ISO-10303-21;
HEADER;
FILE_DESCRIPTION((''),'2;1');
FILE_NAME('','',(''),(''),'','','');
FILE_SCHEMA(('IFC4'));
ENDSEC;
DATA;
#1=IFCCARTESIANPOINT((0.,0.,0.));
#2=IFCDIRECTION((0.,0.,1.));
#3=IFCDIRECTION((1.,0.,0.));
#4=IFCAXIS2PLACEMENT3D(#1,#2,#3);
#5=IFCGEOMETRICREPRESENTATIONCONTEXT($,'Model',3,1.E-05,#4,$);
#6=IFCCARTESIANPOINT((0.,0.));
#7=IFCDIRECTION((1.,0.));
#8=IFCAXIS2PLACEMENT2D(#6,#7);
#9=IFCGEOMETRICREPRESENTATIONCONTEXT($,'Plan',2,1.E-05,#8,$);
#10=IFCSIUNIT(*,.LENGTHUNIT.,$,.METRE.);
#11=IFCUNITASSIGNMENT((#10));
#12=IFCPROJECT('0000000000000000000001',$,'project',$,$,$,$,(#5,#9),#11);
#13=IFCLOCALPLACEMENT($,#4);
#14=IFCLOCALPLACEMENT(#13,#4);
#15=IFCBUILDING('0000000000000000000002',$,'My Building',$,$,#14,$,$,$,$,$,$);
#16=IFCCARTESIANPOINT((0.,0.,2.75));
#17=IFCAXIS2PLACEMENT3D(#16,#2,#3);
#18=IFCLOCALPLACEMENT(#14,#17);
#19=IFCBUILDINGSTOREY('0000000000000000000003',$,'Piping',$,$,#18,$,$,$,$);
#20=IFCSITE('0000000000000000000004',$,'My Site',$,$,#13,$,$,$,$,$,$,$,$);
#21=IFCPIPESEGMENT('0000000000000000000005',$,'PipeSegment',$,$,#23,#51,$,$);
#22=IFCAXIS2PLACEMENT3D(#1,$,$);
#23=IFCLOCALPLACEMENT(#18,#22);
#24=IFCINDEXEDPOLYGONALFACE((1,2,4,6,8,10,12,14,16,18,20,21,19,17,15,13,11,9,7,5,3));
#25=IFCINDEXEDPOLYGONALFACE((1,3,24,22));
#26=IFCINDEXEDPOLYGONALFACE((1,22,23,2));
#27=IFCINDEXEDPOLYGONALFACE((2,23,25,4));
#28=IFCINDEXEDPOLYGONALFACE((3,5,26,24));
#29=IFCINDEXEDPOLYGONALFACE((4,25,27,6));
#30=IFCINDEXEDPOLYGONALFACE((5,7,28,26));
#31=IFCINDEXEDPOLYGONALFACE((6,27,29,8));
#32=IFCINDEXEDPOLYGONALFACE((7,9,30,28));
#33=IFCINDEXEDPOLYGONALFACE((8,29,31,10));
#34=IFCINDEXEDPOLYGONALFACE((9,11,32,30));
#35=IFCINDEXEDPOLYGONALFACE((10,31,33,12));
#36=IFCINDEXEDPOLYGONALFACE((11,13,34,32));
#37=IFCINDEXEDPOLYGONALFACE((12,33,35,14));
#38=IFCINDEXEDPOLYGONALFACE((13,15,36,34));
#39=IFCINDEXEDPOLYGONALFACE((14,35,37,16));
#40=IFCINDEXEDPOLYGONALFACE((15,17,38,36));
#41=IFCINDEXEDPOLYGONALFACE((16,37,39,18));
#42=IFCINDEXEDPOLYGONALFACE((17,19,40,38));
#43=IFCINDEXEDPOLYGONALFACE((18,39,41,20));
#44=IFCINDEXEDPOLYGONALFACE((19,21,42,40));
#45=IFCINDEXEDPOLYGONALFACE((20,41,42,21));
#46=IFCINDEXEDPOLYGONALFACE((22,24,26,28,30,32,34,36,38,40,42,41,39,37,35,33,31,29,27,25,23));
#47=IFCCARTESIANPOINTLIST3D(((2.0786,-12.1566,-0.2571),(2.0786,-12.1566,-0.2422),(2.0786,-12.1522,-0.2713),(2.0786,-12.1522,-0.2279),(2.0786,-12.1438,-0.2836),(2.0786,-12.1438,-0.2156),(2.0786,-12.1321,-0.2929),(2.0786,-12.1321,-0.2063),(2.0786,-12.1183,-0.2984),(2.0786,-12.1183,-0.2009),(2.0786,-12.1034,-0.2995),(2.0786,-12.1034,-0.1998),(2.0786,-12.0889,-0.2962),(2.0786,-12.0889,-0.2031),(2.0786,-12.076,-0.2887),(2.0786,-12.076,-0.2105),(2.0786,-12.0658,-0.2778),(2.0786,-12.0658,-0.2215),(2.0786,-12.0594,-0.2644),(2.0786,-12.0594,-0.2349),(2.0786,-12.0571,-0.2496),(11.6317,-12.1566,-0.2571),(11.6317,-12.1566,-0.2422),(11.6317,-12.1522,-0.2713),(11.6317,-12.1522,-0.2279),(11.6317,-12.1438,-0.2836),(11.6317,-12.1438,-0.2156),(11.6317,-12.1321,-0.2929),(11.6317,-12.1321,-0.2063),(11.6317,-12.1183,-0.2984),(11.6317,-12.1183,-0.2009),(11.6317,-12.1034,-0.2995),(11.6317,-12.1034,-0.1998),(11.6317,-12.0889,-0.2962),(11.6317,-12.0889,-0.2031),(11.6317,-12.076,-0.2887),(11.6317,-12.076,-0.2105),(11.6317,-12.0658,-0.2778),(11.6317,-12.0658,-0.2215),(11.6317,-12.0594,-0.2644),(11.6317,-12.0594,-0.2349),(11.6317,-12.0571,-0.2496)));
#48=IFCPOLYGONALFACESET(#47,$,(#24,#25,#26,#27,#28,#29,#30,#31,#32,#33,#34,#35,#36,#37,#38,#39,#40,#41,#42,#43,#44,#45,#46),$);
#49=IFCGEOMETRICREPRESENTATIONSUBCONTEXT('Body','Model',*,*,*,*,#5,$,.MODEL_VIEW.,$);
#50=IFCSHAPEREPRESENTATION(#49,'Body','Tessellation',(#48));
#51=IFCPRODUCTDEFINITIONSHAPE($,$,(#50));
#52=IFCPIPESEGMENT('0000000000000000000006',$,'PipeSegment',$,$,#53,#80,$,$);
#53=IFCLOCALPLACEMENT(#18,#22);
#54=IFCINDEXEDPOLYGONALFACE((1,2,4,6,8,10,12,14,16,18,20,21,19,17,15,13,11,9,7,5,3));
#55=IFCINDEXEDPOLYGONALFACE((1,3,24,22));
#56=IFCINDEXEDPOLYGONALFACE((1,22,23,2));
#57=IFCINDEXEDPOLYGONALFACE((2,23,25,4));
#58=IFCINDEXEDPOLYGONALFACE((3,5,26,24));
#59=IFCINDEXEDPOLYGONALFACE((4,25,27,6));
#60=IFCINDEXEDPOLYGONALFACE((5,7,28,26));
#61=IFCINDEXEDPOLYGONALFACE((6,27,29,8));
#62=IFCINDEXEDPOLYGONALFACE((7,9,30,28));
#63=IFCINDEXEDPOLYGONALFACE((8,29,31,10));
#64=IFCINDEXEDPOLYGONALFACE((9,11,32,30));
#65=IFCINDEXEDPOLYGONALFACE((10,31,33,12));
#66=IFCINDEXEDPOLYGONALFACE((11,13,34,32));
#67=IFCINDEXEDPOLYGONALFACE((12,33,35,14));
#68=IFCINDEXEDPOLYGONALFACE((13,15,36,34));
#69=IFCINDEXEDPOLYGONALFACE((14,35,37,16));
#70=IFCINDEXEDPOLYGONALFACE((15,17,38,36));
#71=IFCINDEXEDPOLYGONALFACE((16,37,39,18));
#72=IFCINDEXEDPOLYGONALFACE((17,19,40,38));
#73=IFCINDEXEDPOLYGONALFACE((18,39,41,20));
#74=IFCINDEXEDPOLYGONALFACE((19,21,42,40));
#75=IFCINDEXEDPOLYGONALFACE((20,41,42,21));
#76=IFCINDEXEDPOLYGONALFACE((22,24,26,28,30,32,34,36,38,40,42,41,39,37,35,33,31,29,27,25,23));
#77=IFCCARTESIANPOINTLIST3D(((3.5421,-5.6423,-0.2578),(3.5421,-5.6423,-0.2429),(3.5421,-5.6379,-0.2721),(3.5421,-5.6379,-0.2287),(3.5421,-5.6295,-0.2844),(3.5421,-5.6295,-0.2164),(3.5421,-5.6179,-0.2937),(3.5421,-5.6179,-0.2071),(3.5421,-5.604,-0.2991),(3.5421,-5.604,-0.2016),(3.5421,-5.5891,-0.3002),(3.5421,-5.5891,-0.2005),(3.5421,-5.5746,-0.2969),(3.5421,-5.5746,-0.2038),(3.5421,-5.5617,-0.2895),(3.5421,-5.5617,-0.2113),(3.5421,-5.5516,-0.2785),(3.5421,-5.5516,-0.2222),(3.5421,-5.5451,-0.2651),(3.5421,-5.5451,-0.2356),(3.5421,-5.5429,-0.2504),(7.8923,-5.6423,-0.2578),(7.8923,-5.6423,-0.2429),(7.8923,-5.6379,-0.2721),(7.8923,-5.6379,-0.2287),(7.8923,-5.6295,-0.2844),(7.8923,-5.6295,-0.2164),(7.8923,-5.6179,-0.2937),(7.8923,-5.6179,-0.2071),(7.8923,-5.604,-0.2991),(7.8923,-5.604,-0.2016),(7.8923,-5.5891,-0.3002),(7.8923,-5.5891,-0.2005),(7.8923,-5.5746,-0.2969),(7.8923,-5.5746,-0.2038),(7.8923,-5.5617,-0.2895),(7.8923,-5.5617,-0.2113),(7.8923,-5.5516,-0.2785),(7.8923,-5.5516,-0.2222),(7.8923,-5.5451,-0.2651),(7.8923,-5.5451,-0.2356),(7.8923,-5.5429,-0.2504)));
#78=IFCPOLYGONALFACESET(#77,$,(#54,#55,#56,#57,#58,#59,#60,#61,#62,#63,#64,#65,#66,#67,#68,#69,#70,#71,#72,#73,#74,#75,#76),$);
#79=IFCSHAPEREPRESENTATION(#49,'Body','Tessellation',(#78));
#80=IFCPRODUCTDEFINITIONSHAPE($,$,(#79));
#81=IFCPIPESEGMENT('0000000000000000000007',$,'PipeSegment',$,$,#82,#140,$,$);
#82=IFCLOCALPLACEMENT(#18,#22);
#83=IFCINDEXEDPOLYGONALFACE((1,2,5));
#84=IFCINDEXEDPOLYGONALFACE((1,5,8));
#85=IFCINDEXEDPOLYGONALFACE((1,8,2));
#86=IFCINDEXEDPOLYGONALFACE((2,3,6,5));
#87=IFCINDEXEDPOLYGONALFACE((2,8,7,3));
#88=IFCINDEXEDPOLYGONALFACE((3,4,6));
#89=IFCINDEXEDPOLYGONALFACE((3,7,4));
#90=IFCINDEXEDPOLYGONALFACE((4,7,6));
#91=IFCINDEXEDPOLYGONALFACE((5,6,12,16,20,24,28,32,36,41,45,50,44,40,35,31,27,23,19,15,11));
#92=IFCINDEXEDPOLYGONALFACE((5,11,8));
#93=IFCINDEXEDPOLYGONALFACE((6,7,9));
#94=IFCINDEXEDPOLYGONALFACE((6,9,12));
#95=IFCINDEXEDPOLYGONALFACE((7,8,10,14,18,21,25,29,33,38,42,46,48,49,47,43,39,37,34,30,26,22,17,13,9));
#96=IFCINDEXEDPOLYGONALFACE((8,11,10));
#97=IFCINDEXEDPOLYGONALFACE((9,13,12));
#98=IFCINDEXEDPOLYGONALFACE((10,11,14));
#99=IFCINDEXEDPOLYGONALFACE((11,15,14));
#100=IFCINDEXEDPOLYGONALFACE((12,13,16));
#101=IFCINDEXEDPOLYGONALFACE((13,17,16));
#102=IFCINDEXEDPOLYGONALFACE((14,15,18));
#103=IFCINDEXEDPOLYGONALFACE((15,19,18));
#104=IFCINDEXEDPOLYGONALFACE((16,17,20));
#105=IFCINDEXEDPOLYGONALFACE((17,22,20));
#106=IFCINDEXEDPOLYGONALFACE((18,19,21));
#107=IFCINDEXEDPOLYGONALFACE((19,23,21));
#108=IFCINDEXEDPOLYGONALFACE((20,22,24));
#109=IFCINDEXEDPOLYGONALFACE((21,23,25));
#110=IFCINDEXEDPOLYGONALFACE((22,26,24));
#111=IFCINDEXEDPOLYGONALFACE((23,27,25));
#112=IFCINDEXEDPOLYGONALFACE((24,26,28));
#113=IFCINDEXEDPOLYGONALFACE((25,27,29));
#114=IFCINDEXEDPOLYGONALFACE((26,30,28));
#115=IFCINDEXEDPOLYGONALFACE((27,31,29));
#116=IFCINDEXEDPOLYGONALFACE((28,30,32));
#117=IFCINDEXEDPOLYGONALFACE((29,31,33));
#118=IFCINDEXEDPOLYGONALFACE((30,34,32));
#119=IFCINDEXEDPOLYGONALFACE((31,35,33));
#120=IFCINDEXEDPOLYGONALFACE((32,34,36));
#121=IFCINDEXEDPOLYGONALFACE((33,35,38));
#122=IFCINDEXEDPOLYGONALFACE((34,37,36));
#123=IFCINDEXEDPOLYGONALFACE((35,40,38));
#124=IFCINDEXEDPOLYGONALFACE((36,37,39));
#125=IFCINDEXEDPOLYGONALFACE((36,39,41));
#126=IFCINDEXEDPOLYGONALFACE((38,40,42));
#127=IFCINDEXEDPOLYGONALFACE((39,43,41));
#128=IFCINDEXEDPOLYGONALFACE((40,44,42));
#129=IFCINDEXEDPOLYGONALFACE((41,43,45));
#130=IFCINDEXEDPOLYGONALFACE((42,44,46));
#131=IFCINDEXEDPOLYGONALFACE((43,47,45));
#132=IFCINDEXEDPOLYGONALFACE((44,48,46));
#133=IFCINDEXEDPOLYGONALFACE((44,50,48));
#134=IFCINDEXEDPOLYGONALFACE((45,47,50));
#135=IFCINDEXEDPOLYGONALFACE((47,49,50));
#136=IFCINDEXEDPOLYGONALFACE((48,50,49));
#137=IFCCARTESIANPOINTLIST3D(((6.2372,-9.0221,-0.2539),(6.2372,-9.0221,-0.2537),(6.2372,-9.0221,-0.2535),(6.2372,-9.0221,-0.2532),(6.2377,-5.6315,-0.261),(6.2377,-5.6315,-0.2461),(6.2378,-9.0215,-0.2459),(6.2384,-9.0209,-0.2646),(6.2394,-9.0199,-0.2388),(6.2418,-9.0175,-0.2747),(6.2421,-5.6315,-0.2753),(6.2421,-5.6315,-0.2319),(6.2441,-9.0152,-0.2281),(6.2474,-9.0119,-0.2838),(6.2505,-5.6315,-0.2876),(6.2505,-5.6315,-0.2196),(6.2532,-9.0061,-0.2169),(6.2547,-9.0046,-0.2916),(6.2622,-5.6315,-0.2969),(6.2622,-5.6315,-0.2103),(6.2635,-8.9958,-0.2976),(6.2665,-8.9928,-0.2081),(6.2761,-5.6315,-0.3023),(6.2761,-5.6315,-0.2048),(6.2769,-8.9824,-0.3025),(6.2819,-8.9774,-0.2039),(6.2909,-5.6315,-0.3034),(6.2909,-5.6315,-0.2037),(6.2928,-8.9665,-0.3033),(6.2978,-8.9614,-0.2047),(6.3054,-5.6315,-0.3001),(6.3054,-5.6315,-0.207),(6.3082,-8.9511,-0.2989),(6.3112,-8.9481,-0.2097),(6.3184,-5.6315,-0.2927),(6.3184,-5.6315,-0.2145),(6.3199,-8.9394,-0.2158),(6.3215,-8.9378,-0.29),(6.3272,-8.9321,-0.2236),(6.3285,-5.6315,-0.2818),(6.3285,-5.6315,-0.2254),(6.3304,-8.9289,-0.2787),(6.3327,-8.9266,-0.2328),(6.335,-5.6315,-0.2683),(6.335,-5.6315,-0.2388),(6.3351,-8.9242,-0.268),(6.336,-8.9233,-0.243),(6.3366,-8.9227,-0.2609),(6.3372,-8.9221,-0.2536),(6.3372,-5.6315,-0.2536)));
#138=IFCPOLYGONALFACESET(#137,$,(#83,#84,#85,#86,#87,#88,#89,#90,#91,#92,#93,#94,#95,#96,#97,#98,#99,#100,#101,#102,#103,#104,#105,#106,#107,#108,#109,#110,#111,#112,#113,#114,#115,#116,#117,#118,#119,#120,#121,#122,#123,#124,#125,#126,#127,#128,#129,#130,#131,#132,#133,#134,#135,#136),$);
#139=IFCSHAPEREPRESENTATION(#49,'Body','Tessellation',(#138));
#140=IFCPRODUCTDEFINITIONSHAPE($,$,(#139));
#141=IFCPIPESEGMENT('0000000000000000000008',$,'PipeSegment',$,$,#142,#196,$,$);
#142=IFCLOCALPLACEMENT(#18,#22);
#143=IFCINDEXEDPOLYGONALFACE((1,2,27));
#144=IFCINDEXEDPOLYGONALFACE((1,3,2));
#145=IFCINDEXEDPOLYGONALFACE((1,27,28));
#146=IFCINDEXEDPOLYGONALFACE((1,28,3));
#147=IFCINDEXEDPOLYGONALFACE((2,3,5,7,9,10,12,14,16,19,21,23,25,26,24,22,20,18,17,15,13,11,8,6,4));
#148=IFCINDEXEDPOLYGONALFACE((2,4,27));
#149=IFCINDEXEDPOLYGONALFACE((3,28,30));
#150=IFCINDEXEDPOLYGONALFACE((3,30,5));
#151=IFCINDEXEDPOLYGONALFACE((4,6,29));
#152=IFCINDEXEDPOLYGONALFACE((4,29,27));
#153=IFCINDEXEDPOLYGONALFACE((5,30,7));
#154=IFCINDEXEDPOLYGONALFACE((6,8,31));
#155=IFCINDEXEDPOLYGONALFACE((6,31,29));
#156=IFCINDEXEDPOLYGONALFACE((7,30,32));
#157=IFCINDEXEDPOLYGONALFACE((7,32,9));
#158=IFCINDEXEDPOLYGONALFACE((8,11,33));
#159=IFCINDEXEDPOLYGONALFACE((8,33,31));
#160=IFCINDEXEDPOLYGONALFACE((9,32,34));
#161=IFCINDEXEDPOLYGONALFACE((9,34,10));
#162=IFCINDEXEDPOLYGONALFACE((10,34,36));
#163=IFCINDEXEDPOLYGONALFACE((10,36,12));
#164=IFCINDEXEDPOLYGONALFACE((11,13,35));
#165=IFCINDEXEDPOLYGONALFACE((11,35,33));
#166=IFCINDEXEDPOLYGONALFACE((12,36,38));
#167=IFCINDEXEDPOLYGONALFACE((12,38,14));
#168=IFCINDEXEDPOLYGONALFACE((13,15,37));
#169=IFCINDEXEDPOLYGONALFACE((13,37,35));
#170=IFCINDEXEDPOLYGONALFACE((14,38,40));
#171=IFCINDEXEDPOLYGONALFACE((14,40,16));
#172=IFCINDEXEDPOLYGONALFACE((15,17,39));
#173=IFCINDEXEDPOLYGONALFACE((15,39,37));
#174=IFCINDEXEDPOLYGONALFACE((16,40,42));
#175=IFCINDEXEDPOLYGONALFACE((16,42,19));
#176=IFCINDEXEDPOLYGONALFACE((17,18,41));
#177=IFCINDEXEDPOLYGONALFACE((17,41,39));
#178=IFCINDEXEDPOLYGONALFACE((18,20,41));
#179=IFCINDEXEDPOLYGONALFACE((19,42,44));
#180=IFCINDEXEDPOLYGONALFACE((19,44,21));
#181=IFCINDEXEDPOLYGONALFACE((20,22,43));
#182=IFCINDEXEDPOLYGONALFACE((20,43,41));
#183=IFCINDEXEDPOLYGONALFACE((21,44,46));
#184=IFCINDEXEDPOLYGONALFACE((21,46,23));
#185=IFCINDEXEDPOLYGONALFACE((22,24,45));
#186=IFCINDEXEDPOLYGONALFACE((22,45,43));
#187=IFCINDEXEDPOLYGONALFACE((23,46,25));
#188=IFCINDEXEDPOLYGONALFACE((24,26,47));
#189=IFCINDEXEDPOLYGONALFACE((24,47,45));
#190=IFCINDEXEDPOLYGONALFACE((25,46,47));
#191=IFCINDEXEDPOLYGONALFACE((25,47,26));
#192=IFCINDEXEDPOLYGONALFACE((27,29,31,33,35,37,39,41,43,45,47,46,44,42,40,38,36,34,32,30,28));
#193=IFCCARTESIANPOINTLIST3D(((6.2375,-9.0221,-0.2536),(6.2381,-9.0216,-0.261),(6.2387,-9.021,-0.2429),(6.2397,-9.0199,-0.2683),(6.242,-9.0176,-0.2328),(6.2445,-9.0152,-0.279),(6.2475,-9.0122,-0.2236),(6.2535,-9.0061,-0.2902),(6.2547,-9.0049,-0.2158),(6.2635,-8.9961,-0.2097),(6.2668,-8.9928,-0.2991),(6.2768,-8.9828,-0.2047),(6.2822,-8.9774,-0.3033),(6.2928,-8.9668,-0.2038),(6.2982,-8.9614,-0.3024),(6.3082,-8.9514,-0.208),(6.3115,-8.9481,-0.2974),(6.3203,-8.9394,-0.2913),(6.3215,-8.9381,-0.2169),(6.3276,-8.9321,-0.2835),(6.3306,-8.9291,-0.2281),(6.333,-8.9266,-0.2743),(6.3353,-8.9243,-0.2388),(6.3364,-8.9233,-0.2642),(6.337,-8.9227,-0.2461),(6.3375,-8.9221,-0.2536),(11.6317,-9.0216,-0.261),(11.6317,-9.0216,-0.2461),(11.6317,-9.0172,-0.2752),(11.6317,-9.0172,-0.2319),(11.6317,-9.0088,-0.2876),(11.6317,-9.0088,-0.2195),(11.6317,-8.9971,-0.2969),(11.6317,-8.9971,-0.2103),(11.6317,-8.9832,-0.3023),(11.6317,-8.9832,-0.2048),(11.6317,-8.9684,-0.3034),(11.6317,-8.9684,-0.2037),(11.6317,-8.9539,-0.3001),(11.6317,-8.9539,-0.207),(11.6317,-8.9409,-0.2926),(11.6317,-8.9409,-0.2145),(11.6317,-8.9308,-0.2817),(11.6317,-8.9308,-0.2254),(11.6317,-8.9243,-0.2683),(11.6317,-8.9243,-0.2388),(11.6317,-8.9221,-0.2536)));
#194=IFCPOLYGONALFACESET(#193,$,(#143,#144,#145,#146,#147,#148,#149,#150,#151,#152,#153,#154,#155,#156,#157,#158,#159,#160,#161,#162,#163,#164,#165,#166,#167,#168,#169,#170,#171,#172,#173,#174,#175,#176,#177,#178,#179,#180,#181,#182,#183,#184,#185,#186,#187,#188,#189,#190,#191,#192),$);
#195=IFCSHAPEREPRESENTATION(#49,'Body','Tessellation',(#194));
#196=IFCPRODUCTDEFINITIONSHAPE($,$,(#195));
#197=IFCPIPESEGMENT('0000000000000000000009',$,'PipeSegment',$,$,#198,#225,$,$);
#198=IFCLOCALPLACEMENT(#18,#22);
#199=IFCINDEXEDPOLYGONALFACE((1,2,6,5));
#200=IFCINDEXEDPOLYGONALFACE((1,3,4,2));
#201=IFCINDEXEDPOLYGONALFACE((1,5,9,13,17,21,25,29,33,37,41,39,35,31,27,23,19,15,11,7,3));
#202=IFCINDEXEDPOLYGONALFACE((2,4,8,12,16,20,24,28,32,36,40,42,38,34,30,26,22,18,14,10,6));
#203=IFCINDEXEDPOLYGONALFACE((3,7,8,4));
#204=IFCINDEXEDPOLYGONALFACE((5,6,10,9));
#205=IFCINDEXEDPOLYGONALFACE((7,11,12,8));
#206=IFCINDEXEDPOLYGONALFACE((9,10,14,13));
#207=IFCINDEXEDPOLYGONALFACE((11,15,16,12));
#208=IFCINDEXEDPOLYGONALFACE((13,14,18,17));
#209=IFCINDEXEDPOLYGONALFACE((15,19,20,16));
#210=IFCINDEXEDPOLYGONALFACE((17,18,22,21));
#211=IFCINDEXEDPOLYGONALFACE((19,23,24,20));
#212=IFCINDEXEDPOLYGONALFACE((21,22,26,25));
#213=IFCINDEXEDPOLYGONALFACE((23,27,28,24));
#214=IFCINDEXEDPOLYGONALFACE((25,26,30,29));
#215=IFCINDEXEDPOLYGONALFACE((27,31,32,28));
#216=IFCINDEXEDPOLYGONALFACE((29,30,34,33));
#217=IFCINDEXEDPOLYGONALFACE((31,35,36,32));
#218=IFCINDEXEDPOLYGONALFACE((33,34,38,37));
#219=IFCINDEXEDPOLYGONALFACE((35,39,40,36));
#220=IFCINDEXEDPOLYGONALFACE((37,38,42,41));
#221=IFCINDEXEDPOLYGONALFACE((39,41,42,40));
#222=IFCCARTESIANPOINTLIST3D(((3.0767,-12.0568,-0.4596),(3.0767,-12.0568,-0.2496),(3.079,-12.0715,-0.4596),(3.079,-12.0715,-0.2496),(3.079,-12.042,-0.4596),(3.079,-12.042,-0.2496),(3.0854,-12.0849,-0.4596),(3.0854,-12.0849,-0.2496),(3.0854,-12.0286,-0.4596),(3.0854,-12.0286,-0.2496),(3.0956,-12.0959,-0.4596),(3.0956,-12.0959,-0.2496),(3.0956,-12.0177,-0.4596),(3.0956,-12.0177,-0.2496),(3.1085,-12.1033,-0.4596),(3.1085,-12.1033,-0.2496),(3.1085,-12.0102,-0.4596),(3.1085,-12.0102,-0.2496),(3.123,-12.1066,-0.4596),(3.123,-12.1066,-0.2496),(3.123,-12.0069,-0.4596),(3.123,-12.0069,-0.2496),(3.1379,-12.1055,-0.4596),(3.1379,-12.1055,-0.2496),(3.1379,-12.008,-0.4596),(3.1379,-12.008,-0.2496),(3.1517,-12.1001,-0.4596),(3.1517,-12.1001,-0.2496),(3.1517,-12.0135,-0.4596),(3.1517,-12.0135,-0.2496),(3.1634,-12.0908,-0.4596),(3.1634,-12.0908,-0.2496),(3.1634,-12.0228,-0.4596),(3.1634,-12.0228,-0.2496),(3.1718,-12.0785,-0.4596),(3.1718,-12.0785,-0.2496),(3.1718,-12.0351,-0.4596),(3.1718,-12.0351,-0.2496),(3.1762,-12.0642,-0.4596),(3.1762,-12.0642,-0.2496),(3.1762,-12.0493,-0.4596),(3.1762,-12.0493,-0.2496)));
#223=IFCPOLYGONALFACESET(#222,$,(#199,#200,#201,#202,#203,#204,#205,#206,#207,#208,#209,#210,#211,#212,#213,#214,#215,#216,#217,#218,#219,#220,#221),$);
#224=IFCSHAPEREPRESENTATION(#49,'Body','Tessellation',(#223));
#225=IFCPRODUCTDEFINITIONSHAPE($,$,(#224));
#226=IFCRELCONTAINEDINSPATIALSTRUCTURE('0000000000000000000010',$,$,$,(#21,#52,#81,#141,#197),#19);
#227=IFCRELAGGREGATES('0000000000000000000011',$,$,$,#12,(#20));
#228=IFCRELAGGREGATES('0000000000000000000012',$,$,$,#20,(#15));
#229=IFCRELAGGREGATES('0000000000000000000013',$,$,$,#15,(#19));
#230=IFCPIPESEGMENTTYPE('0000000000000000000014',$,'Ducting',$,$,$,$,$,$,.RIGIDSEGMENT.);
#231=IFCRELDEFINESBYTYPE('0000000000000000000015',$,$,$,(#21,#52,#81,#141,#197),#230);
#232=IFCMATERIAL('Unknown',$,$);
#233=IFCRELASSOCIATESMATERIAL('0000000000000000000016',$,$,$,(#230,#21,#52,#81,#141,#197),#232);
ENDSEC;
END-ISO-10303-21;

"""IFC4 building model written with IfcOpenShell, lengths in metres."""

from ifc_helpers import new_model, si_unit, frame, origin_with_axes, origin_2d_with_axis, place, context, subcontext, project, spatial, circle, extrude, clip, halfspace, material, material_profile, profile_set, profile_usage, type_object, element, save


model = new_model("IFC4")

# Units and contexts
model_context = context("Model", 3, precision=1e-05, world=origin_with_axes())
plan_context = context("Plan", 2, precision=1e-05, world=origin_2d_with_axis())
body_context = subcontext(model_context, "Body", "Model", "MODEL_VIEW")
ifc_project = project(units=[si_unit("LENGTHUNIT", "METRE")], contexts=[model_context, plan_context])

# Site, building, storey
site_placement = place(None, origin_with_axes())
site = spatial("IfcSite", under=ifc_project, at=site_placement, Name="My Site")
building_placement = place(site_placement, origin_with_axes())
building = spatial("IfcBuilding", under=site, at=building_placement, Name="My Building")
storey_placement = place(building_placement, frame((0.0, 0.0, 2.75), z_axis=(0.0, 0.0, 1.0), x_axis=(1.0, 0.0, 0.0)))
storey = spatial("IfcBuildingStorey", under=building, at=storey_placement, Name="Piping")

# Pipe segments
ifc_material = material(Name="Unknown")
ifc_material_profile = material_profile(ifc_material, circle(Radius=0.05))
ifc_profile_set = profile_set([ifc_material_profile])
ifc_profile_usage_1 = profile_usage(ifc_profile_set, cardinal=4)
pipe_segment_type = type_object("IfcPipeSegmentType", Name="Ducting", PredefinedType="RIGIDSEGMENT", material=ifc_profile_set)
pipe_segment_1_placement = place(storey_placement, frame((2.0786, -12.0571, -0.2496), z_axis=(1.0, 0.0, 0.0), x_axis=(0.0, 1.0, 0.0)))
element("IfcPipeSegment", 1, at=pipe_segment_1_placement, inside=storey, type_object=pipe_segment_type, material=ifc_profile_usage_1, Name="PipeSegment", context=body_context, shape_type="SweptSolid", body=[
    extrude(circle(Radius=0.05), frame((-0.05, 0.0, 0.0), z_axis=(0.0, 0.0, 1.0), x_axis=(1.0, 0.0, 0.0)), (0.0, 0.0, 1.0), 9.553),
])
ifc_profile_usage_2 = profile_usage(ifc_profile_set, cardinal=4)
pipe_segment_2_placement = place(storey_placement, frame((3.5421, -5.5429, -0.2504), z_axis=(1.0, -0.000001, 0.000001), x_axis=(0.000001, 1.0, 0.0)))
element("IfcPipeSegment", 2, at=pipe_segment_2_placement, inside=storey, type_object=pipe_segment_type, material=ifc_profile_usage_2, Name="PipeSegment", context=body_context, shape_type="SweptSolid", body=[
    extrude(circle(Radius=0.05), frame((-0.05, 0.0, 0.0), z_axis=(0.0, 0.0, 1.0), x_axis=(1.0, 0.0, 0.0)), (0.0, 0.0, 1.0), 4.3502),
])
ifc_profile_usage_3 = profile_usage(ifc_profile_set, cardinal=4)
pipe_segment_3_placement = place(storey_placement, frame((6.3372, -5.6315, -0.2536), z_axis=(0.0, -1.0, 0.0), x_axis=(1.0, 0.0, 0.0)))
element("IfcPipeSegment", 3, at=pipe_segment_3_placement, inside=storey, type_object=pipe_segment_type, material=ifc_profile_usage_3, Name="PipeSegment", context=body_context, shape_type="Clipping", body=[
    clip(extrude(circle(Radius=0.05), frame((-0.05, 0.0, 0.0), z_axis=(0.0, 0.0, 1.0), x_axis=(1.0, 0.0, 0.0)), (0.0, 0.0, 1.0), 3.3906), halfspace(frame((-0.1, -2.4509, 3.3906), z_axis=(0.707109, 0.0, 0.707105), x_axis=(0.0, -1.0, 0.0)), False)),
])
ifc_profile_usage_4 = profile_usage(ifc_profile_set, cardinal=4)
pipe_segment_4_placement = place(storey_placement, frame((6.2375, -8.9221, -0.2536), z_axis=(1.0, -0.000001, 0.000001), x_axis=(0.000001, 1.0, 0.0)))
element("IfcPipeSegment", 4, at=pipe_segment_4_placement, inside=storey, type_object=pipe_segment_type, material=ifc_profile_usage_4, Name="PipeSegment", context=body_context, shape_type="Clipping", body=[
    clip(extrude(circle(Radius=0.05), frame((-0.05, 0.0, 0.0), z_axis=(0.0, 0.0, 1.0), x_axis=(1.0, 0.0, 0.0)), (0.0, 0.0, 1.0), 5.3942), halfspace(frame((-0.1, -2.4509, 0.0), z_axis=(0.707105, 0.0, -0.707109), x_axis=(0.000001, -1.0, 0.0)), False)),
])
ifc_profile_usage_5 = profile_usage(ifc_profile_set, cardinal=4)
pipe_segment_5_placement = place(storey_placement, frame((3.0767, -12.0568, -0.2496), z_axis=(0.0, 0.0, -1.0), x_axis=(-1.0, 0.0, 0.0)))
element("IfcPipeSegment", 5, at=pipe_segment_5_placement, inside=storey, type_object=pipe_segment_type, material=ifc_profile_usage_5, Name="PipeSegment", context=body_context, shape_type="SweptSolid", body=[
    extrude(circle(Radius=0.05), frame((-0.05, 0.0, 0.0), z_axis=(0.0, 0.0, 1.0), x_axis=(1.0, 0.0, 0.0)), (0.0, 0.0, 1.0), 0.21),
])

save(model, "model.ifc")
